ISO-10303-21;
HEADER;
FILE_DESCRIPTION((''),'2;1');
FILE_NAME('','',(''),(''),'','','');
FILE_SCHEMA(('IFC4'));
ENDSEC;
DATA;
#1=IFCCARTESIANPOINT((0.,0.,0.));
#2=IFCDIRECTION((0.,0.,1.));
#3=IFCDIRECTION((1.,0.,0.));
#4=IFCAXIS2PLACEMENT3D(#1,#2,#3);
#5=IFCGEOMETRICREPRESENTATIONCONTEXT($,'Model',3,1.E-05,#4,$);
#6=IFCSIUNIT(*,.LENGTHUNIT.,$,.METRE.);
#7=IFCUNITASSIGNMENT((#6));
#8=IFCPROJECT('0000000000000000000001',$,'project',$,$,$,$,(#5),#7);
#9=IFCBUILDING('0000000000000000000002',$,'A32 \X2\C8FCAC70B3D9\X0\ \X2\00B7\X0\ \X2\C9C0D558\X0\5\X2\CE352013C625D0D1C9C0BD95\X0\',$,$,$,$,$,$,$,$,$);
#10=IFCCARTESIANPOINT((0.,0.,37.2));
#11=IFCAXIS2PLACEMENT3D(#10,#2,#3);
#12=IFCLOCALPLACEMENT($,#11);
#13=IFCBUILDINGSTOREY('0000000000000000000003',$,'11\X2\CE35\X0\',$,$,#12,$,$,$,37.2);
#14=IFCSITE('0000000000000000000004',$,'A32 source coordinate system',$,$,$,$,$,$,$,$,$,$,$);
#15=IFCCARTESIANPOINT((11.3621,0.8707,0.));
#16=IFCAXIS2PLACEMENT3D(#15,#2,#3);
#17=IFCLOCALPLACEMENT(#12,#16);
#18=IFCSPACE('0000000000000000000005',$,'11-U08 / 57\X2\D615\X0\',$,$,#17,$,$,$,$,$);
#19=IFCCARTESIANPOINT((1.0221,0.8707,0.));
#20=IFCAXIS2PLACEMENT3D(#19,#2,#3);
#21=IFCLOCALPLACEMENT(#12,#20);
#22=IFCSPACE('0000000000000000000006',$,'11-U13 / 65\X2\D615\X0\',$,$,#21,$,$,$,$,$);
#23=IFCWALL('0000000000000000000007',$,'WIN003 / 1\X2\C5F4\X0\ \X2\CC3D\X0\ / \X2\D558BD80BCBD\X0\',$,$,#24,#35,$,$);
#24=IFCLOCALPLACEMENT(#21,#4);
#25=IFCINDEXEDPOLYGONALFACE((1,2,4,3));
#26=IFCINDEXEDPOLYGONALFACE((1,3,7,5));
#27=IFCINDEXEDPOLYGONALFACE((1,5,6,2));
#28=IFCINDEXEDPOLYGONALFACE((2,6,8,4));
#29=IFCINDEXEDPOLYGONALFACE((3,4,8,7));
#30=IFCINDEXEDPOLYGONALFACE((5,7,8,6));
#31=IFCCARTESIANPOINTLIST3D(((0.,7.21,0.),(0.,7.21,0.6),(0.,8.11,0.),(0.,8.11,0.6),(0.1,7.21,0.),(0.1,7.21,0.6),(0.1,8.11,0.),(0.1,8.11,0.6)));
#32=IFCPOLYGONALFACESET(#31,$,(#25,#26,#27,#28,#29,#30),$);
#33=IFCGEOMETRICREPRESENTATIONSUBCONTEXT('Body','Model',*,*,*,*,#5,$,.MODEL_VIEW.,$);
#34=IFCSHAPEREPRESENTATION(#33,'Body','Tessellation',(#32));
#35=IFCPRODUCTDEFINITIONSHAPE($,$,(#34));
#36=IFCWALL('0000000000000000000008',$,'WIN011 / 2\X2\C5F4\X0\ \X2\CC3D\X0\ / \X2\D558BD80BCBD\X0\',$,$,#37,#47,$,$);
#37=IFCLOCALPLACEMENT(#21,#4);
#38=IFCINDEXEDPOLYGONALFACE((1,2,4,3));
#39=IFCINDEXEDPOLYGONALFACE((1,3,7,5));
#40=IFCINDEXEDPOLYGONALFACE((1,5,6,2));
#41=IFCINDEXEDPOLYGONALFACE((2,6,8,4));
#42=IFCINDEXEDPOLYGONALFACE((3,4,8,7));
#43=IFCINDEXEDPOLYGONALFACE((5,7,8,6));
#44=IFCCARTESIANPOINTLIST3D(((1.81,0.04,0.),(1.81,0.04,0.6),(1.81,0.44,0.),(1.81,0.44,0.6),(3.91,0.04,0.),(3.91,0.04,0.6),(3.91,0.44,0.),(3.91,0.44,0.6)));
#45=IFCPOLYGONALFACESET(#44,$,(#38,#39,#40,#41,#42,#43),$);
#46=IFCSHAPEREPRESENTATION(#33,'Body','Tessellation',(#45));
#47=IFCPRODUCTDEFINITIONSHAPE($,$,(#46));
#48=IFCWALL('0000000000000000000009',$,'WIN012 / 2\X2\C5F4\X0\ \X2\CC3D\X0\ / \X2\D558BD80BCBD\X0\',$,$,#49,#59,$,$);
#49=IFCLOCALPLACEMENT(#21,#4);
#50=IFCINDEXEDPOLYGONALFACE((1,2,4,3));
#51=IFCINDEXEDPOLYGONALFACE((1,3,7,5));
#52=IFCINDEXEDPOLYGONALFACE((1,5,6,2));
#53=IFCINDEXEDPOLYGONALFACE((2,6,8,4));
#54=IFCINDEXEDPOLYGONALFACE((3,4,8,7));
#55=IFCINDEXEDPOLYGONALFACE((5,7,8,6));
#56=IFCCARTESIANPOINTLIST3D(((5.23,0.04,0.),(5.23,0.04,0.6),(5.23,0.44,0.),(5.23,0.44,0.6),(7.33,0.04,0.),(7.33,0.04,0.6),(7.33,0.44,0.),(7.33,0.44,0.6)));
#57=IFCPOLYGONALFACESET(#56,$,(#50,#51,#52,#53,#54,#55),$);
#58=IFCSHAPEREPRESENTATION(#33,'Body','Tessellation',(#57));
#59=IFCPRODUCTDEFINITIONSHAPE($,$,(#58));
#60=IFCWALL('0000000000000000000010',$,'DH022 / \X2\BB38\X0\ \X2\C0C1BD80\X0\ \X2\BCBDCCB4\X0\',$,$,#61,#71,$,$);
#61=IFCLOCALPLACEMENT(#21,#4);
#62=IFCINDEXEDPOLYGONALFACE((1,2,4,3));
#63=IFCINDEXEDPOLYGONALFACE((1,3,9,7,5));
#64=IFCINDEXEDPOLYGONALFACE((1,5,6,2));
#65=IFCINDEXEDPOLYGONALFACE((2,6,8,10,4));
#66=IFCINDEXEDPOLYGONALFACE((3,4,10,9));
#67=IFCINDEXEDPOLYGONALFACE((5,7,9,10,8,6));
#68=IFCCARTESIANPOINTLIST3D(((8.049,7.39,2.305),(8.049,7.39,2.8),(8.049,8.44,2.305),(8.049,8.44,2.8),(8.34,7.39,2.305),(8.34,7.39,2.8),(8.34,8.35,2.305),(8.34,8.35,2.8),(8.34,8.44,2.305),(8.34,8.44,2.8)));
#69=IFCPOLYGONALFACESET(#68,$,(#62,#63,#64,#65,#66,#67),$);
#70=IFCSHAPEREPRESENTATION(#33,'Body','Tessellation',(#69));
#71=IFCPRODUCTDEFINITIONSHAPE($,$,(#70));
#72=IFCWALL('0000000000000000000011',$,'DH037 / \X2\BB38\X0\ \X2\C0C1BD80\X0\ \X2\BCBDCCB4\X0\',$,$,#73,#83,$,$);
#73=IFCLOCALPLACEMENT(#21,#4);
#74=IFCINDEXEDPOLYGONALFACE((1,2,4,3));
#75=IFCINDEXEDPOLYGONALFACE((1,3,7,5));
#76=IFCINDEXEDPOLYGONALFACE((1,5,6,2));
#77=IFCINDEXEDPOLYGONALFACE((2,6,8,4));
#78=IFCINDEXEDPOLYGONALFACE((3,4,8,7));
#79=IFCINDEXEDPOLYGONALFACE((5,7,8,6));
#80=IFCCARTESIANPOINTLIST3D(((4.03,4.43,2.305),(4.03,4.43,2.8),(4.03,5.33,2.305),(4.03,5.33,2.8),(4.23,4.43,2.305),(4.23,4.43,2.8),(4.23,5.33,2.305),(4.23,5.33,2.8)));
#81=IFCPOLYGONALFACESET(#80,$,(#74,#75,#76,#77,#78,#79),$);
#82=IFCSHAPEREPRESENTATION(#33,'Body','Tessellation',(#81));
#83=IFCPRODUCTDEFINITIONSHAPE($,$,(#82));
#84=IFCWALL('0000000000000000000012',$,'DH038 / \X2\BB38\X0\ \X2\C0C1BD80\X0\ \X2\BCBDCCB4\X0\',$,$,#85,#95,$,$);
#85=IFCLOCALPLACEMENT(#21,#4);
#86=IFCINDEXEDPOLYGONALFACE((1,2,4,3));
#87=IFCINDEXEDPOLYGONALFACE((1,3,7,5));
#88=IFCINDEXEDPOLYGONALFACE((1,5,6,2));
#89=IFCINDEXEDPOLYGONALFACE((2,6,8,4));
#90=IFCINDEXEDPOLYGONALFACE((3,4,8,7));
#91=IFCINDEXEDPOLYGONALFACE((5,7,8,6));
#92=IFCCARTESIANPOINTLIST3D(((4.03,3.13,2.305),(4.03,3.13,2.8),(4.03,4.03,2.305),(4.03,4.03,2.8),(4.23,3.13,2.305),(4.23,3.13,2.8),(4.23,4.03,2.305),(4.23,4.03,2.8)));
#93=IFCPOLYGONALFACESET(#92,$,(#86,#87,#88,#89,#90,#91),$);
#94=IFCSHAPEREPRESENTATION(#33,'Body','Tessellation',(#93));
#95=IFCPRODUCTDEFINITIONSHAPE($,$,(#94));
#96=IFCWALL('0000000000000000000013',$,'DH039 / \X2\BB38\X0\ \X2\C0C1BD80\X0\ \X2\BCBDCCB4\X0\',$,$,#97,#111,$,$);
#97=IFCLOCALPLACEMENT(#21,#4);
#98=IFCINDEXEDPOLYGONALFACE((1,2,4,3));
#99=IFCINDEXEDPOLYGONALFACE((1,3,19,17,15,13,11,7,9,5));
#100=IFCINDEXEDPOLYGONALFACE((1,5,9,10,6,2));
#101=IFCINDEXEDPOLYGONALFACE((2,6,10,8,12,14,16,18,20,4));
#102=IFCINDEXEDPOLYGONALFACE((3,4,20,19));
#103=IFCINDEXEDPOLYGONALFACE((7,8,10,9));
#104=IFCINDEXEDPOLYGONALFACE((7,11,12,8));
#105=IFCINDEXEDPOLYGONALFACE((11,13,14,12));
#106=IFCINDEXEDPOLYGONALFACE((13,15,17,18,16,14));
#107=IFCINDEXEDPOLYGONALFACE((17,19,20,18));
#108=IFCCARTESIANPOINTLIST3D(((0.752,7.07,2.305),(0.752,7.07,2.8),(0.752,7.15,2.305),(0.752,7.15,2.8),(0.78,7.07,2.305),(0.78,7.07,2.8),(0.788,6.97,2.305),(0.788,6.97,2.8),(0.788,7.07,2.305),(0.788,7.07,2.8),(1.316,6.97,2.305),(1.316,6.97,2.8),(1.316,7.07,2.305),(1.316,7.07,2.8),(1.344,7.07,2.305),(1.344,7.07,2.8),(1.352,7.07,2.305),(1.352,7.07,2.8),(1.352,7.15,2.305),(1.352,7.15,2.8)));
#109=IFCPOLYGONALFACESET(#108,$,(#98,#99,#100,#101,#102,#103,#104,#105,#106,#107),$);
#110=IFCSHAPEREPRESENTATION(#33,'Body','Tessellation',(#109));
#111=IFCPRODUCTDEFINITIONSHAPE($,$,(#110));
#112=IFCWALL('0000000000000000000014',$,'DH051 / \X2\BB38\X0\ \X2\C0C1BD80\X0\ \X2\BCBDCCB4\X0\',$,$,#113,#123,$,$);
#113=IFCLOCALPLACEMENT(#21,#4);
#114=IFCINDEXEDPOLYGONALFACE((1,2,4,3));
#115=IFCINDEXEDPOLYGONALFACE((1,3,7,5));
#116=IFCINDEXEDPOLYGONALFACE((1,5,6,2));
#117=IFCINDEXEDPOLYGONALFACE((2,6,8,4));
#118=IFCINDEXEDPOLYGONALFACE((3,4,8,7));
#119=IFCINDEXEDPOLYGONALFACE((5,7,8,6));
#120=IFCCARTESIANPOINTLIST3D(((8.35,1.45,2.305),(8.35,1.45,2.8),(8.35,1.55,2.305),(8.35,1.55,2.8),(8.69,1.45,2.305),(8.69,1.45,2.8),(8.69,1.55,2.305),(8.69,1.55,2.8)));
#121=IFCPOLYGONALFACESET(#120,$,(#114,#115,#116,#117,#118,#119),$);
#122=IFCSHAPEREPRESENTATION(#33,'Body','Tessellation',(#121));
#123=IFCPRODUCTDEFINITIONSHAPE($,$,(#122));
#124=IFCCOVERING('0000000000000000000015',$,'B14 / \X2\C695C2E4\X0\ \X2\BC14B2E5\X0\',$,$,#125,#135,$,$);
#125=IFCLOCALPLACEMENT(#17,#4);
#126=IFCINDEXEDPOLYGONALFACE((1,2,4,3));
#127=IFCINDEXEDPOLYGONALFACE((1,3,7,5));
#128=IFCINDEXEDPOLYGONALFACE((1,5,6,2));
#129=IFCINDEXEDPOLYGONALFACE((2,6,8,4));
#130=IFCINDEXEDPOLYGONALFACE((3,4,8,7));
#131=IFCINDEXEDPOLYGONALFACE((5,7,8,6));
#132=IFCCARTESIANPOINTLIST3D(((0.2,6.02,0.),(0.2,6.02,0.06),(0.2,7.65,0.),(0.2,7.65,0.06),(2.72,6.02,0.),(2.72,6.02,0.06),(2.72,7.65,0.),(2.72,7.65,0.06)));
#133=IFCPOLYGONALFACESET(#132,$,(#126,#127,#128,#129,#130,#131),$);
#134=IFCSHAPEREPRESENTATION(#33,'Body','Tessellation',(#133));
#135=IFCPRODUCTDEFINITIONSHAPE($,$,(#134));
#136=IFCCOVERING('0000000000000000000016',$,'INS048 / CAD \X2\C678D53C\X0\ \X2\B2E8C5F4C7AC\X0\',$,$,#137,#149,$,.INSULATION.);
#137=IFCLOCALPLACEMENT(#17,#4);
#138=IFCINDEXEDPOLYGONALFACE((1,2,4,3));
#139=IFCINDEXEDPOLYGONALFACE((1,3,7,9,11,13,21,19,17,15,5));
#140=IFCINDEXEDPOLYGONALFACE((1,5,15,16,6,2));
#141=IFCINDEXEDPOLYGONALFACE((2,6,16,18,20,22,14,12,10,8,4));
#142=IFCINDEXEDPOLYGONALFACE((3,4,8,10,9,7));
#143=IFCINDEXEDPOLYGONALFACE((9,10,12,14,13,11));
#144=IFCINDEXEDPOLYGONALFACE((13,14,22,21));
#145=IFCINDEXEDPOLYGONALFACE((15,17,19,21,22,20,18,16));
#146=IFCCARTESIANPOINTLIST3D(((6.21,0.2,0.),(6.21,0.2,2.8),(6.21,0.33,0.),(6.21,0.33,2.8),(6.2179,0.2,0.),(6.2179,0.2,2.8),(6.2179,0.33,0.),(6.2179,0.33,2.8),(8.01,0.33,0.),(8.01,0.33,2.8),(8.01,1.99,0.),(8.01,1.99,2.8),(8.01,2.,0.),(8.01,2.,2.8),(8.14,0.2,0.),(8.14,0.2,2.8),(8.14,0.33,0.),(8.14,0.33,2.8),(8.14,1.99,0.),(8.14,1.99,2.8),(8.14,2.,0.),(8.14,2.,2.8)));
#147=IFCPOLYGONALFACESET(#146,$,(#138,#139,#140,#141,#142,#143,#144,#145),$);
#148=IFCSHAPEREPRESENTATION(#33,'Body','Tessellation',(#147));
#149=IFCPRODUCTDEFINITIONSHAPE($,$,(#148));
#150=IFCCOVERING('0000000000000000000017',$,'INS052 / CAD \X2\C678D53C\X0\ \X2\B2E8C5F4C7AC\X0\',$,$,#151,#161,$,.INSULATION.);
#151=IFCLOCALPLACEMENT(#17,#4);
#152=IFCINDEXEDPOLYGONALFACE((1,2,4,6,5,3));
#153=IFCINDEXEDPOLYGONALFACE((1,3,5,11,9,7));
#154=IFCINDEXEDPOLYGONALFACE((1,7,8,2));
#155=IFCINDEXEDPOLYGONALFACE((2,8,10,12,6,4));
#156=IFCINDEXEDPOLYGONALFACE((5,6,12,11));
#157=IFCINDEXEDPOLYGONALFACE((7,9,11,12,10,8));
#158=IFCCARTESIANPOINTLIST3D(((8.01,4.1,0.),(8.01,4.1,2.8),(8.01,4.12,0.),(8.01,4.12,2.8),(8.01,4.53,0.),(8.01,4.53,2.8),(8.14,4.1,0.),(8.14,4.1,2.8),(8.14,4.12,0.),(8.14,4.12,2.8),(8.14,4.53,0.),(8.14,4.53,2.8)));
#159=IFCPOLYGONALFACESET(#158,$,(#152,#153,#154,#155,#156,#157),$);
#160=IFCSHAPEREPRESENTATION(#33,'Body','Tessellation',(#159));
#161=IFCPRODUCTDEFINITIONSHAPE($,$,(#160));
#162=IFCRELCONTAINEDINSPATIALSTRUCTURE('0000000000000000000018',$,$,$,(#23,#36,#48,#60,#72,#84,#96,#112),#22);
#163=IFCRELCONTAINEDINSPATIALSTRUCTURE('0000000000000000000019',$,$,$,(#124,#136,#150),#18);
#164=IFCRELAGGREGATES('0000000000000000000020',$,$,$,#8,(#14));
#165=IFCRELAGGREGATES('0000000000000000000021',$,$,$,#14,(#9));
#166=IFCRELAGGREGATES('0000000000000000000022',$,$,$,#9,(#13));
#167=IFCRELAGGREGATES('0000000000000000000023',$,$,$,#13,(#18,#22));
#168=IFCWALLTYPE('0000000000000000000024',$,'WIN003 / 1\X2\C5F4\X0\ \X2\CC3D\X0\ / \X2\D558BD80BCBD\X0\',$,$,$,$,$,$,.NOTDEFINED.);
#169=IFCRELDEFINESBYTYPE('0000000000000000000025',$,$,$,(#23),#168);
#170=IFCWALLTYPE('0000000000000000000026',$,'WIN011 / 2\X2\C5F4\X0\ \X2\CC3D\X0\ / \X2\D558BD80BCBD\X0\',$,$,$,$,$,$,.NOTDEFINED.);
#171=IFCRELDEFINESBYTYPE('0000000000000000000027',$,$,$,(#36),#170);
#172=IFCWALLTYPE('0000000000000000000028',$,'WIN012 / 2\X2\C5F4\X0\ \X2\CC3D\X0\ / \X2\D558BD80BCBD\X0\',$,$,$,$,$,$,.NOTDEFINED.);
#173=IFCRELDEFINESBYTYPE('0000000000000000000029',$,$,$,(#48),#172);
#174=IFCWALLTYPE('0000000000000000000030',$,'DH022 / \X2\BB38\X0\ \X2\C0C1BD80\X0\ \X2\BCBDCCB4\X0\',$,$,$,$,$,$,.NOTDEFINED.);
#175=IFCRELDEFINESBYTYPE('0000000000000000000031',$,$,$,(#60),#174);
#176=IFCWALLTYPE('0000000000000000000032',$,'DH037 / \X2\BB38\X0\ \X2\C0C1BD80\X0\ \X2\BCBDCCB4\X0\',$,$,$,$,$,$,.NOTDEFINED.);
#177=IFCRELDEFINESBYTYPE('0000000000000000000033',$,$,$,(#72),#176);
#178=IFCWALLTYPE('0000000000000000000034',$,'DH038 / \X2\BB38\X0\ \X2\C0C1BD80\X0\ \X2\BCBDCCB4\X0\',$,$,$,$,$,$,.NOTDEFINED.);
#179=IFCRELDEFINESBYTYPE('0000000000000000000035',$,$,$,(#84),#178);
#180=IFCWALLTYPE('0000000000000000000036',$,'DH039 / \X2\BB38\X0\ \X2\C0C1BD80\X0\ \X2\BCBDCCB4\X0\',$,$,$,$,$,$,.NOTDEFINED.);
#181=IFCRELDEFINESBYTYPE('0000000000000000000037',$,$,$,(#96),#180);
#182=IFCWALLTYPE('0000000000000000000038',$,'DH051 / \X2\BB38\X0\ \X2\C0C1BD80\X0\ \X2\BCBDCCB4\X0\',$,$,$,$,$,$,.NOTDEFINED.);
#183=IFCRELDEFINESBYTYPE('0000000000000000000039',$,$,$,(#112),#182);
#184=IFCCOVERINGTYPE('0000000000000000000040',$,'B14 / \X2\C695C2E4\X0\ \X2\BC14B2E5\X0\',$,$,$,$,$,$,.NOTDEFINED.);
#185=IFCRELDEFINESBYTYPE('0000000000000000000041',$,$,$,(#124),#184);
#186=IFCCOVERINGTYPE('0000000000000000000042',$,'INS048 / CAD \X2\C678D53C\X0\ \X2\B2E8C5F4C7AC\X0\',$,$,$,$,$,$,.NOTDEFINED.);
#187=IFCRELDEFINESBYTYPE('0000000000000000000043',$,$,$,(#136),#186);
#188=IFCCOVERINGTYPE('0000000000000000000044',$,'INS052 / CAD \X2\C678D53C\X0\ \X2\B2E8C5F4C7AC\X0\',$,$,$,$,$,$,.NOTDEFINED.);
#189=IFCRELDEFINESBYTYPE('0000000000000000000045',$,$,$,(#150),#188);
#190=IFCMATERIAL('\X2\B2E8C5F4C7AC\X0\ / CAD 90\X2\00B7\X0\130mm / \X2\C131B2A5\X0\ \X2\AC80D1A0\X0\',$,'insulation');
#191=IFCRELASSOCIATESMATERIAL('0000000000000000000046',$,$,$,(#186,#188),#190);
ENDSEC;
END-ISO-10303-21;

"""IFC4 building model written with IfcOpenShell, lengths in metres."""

from ifc_helpers import new_model, si_unit, frame, origin, origin_with_axes, place, context, subcontext, project, spatial, polyline, outline, extrude, source, transform, mapped, material, type_object, type_shapes, element, save


model = new_model("IFC4")

# Units and contexts
model_context = context("Model", 3, precision=1e-05, world=origin_with_axes())
body_context = subcontext(model_context, "Body", "Model", "MODEL_VIEW")
ifc_project = project(units=[si_unit("LENGTHUNIT", "METRE")], contexts=[model_context])

# Site, building, storey, space
site = spatial("IfcSite", under=ifc_project, Name="A32 source coordinate system")
building = spatial("IfcBuilding", under=site, Name="A32 주거동 · 지하5층–옥탑지붕")
storey_placement = place(None, frame((0.0, 0.0, 37.2), z_axis=(0.0, 0.0, 1.0), x_axis=(1.0, 0.0, 0.0)))
storey = spatial("IfcBuildingStorey", under=building, at=storey_placement, Name="11층", Elevation=37.2)
space_1_placement = place(storey_placement, frame((11.3621, 0.8707, 0.0), z_axis=(0.0, 0.0, 1.0), x_axis=(1.0, 0.0, 0.0)))
space_1 = spatial("IfcSpace", under=storey, at=space_1_placement, Name="11-U08 / 57형")

# Shared definitions
space_2_placement = place(storey_placement, frame((1.0221, 0.8707, 0.0), z_axis=(0.0, 0.0, 1.0), x_axis=(1.0, 0.0, 0.0)))
space_2 = spatial("IfcSpace", under=storey, at=space_2_placement, Name="11-U13 / 65형")

# Walls
wall_type_1 = type_object("IfcWallType", Name="WIN003 / 1열 창 / 하부벽", PredefinedType="NOTDEFINED")
shared_shape_1 = source(origin(), body_context, "Body", "SweptSolid", [
    extrude(outline(polyline([(0.0, 8.11), (0.1, 8.11), (0.1, 7.21), (0.0, 7.21), (0.0, 8.11)])), origin(), (0.0, 0.0, 1.0), 0.6),
])
type_shapes(wall_type_1, [shared_shape_1])
wall_1_placement = place(space_2_placement, origin_with_axes())
element("IfcWall", 1, at=wall_1_placement, inside=space_2, type_object=wall_type_1, Name="WIN003 / 1열 창 / 하부벽", context=body_context, shape_type="MappedRepresentation", body=[
    mapped(shared_shape_1, transform((0.0, 0.0, 0.0), scale=1.0)),
])
wall_type_2 = type_object("IfcWallType", Name="WIN011 / 2열 창 / 하부벽", PredefinedType="NOTDEFINED")
shared_shape_2 = source(origin(), body_context, "Body", "SweptSolid", [
    extrude(outline(polyline([(1.81, 0.44), (3.91, 0.44), (3.91, 0.04), (1.81, 0.04), (1.81, 0.44)])), origin(), (0.0, 0.0, 1.0), 0.6),
])
type_shapes(wall_type_2, [shared_shape_2])
wall_2_placement = place(space_2_placement, origin_with_axes())
element("IfcWall", 2, at=wall_2_placement, inside=space_2, type_object=wall_type_2, Name="WIN011 / 2열 창 / 하부벽", context=body_context, shape_type="MappedRepresentation", body=[
    mapped(shared_shape_2, transform((0.0, 0.0, 0.0), scale=1.0)),
])
wall_type_3 = type_object("IfcWallType", Name="WIN012 / 2열 창 / 하부벽", PredefinedType="NOTDEFINED")
shared_shape_3 = source(origin(), body_context, "Body", "SweptSolid", [
    extrude(outline(polyline([(5.23, 0.44), (7.33, 0.44), (7.33, 0.04), (5.23, 0.04), (5.23, 0.44)])), origin(), (0.0, 0.0, 1.0), 0.6),
])
type_shapes(wall_type_3, [shared_shape_3])
wall_3_placement = place(space_2_placement, origin_with_axes())
element("IfcWall", 3, at=wall_3_placement, inside=space_2, type_object=wall_type_3, Name="WIN012 / 2열 창 / 하부벽", context=body_context, shape_type="MappedRepresentation", body=[
    mapped(shared_shape_3, transform((0.0, 0.0, 0.0), scale=1.0)),
])
wall_type_4 = type_object("IfcWallType", Name="DH022 / 문 상부 벽체", PredefinedType="NOTDEFINED")
shared_shape_4 = source(origin(), body_context, "Body", "SweptSolid", [
    extrude(outline(polyline([(8.049, 7.39), (8.049, 8.44), (8.34, 8.44), (8.34, 8.35), (8.34, 8.35), (8.34, 7.39), (8.049, 7.39)])), frame((0.0, 0.0, 2.305)), (0.0, 0.0, 1.0), 0.495),
])
type_shapes(wall_type_4, [shared_shape_4])
wall_4_placement = place(space_2_placement, origin_with_axes())
element("IfcWall", 4, at=wall_4_placement, inside=space_2, type_object=wall_type_4, Name="DH022 / 문 상부 벽체", context=body_context, shape_type="MappedRepresentation", body=[
    mapped(shared_shape_4, transform((0.0, 0.0, 0.0), scale=1.0)),
])
wall_type_5 = type_object("IfcWallType", Name="DH037 / 문 상부 벽체", PredefinedType="NOTDEFINED")
shared_shape_5 = source(origin(), body_context, "Body", "SweptSolid", [
    extrude(outline(polyline([(4.23, 5.33), (4.23, 4.43), (4.03, 4.43), (4.03, 5.33), (4.23, 5.33)])), frame((0.0, 0.0, 2.305)), (0.0, 0.0, 1.0), 0.495),
])
type_shapes(wall_type_5, [shared_shape_5])
wall_5_placement = place(space_2_placement, origin_with_axes())
element("IfcWall", 5, at=wall_5_placement, inside=space_2, type_object=wall_type_5, Name="DH037 / 문 상부 벽체", context=body_context, shape_type="MappedRepresentation", body=[
    mapped(shared_shape_5, transform((0.0, 0.0, 0.0), scale=1.0)),
])
wall_type_6 = type_object("IfcWallType", Name="DH038 / 문 상부 벽체", PredefinedType="NOTDEFINED")
shared_shape_6 = source(origin(), body_context, "Body", "SweptSolid", [
    extrude(outline(polyline([(4.23, 4.03), (4.23, 3.13), (4.03, 3.13), (4.03, 4.03), (4.23, 4.03)])), frame((0.0, 0.0, 2.305)), (0.0, 0.0, 1.0), 0.495),
])
type_shapes(wall_type_6, [shared_shape_6])
wall_6_placement = place(space_2_placement, origin_with_axes())
element("IfcWall", 6, at=wall_6_placement, inside=space_2, type_object=wall_type_6, Name="DH038 / 문 상부 벽체", context=body_context, shape_type="MappedRepresentation", body=[
    mapped(shared_shape_6, transform((0.0, 0.0, 0.0), scale=1.0)),
])
wall_type_7 = type_object("IfcWallType", Name="DH039 / 문 상부 벽체", PredefinedType="NOTDEFINED")
shared_shape_7 = source(origin(), body_context, "Body", "SweptSolid", [
    extrude(outline(polyline([(1.316, 7.07), (1.316, 6.97), (0.788, 6.97), (0.788, 7.07), (0.78, 7.07), (0.752, 7.07), (0.752, 7.15), (1.352, 7.15), (1.352, 7.07), (1.344, 7.07), (1.316, 7.07)])), frame((0.0, 0.0, 2.305)), (0.0, 0.0, 1.0), 0.495),
])
type_shapes(wall_type_7, [shared_shape_7])
wall_7_placement = place(space_2_placement, origin_with_axes())
element("IfcWall", 7, at=wall_7_placement, inside=space_2, type_object=wall_type_7, Name="DH039 / 문 상부 벽체", context=body_context, shape_type="MappedRepresentation", body=[
    mapped(shared_shape_7, transform((0.0, 0.0, 0.0), scale=1.0)),
])
wall_type_8 = type_object("IfcWallType", Name="DH051 / 문 상부 벽체", PredefinedType="NOTDEFINED")
shared_shape_8 = source(origin(), body_context, "Body", "SweptSolid", [
    extrude(outline(polyline([(8.69, 1.55), (8.69, 1.45), (8.35, 1.45), (8.35, 1.55), (8.69, 1.55)])), frame((0.0, 0.0, 2.305)), (0.0, 0.0, 1.0), 0.495),
])
type_shapes(wall_type_8, [shared_shape_8])
wall_8_placement = place(space_2_placement, origin_with_axes())
element("IfcWall", 8, at=wall_8_placement, inside=space_2, type_object=wall_type_8, Name="DH051 / 문 상부 벽체", context=body_context, shape_type="MappedRepresentation", body=[
    mapped(shared_shape_8, transform((0.0, 0.0, 0.0), scale=1.0)),
])

# Coverings
covering_type_1 = type_object("IfcCoveringType", Name="B14 / 욕실 바닥", PredefinedType="NOTDEFINED")
shared_shape_9 = source(origin(), body_context, "Body", "SweptSolid", [
    extrude(outline(polyline([(0.2, 7.65), (2.72, 7.65), (2.72, 6.02), (0.2, 6.02), (0.2, 7.65)])), origin(), (0.0, 0.0, 1.0), 0.06),
])
type_shapes(covering_type_1, [shared_shape_9])
covering_1_placement = place(space_1_placement, origin_with_axes())
element("IfcCovering", 9, at=covering_1_placement, inside=space_1, type_object=covering_type_1, Name="B14 / 욕실 바닥", context=body_context, shape_type="MappedRepresentation", body=[
    mapped(shared_shape_9, transform((0.0, 0.0, 0.0), scale=1.0)),
])
ifc_material = material(Name="단열재 / CAD 90·130mm / 성능 검토", Category="insulation")
covering_type_2 = type_object("IfcCoveringType", Name="INS048 / CAD 외피 단열재", PredefinedType="NOTDEFINED", material=ifc_material)
shared_shape_10 = source(origin(), body_context, "Body", "SweptSolid", [
    extrude(outline(polyline([(8.01, 1.99), (8.01, 2.0), (8.14, 2.0), (8.14, 1.99), (8.14, 0.33), (8.14, 0.2), (6.2179, 0.2), (6.21, 0.2), (6.21, 0.33), (6.2179, 0.33), (8.01, 0.33), (8.01, 1.99)])), origin(), (0.0, 0.0, 1.0), 2.8),
])
type_shapes(covering_type_2, [shared_shape_10])
covering_2_placement = place(space_1_placement, origin_with_axes())
element("IfcCovering", 10, at=covering_2_placement, inside=space_1, type_object=covering_type_2, Name="INS048 / CAD 외피 단열재", PredefinedType="INSULATION", context=body_context, shape_type="MappedRepresentation", body=[
    mapped(shared_shape_10, transform((0.0, 0.0, 0.0), scale=1.0)),
])
covering_type_3 = type_object("IfcCoveringType", Name="INS052 / CAD 외피 단열재", PredefinedType="NOTDEFINED", material=ifc_material)
shared_shape_11 = source(origin(), body_context, "Body", "SweptSolid", [
    extrude(outline(polyline([(8.14, 4.1), (8.01, 4.1), (8.01, 4.12), (8.01, 4.53), (8.14, 4.53), (8.14, 4.12), (8.14, 4.1)])), origin(), (0.0, 0.0, 1.0), 2.8),
])
type_shapes(covering_type_3, [shared_shape_11])
covering_3_placement = place(space_1_placement, origin_with_axes())
element("IfcCovering", 11, at=covering_3_placement, inside=space_1, type_object=covering_type_3, Name="INS052 / CAD 외피 단열재", PredefinedType="INSULATION", context=body_context, shape_type="MappedRepresentation", body=[
    mapped(shared_shape_11, transform((0.0, 0.0, 0.0), scale=1.0)),
])

save(model, "model.ifc")
